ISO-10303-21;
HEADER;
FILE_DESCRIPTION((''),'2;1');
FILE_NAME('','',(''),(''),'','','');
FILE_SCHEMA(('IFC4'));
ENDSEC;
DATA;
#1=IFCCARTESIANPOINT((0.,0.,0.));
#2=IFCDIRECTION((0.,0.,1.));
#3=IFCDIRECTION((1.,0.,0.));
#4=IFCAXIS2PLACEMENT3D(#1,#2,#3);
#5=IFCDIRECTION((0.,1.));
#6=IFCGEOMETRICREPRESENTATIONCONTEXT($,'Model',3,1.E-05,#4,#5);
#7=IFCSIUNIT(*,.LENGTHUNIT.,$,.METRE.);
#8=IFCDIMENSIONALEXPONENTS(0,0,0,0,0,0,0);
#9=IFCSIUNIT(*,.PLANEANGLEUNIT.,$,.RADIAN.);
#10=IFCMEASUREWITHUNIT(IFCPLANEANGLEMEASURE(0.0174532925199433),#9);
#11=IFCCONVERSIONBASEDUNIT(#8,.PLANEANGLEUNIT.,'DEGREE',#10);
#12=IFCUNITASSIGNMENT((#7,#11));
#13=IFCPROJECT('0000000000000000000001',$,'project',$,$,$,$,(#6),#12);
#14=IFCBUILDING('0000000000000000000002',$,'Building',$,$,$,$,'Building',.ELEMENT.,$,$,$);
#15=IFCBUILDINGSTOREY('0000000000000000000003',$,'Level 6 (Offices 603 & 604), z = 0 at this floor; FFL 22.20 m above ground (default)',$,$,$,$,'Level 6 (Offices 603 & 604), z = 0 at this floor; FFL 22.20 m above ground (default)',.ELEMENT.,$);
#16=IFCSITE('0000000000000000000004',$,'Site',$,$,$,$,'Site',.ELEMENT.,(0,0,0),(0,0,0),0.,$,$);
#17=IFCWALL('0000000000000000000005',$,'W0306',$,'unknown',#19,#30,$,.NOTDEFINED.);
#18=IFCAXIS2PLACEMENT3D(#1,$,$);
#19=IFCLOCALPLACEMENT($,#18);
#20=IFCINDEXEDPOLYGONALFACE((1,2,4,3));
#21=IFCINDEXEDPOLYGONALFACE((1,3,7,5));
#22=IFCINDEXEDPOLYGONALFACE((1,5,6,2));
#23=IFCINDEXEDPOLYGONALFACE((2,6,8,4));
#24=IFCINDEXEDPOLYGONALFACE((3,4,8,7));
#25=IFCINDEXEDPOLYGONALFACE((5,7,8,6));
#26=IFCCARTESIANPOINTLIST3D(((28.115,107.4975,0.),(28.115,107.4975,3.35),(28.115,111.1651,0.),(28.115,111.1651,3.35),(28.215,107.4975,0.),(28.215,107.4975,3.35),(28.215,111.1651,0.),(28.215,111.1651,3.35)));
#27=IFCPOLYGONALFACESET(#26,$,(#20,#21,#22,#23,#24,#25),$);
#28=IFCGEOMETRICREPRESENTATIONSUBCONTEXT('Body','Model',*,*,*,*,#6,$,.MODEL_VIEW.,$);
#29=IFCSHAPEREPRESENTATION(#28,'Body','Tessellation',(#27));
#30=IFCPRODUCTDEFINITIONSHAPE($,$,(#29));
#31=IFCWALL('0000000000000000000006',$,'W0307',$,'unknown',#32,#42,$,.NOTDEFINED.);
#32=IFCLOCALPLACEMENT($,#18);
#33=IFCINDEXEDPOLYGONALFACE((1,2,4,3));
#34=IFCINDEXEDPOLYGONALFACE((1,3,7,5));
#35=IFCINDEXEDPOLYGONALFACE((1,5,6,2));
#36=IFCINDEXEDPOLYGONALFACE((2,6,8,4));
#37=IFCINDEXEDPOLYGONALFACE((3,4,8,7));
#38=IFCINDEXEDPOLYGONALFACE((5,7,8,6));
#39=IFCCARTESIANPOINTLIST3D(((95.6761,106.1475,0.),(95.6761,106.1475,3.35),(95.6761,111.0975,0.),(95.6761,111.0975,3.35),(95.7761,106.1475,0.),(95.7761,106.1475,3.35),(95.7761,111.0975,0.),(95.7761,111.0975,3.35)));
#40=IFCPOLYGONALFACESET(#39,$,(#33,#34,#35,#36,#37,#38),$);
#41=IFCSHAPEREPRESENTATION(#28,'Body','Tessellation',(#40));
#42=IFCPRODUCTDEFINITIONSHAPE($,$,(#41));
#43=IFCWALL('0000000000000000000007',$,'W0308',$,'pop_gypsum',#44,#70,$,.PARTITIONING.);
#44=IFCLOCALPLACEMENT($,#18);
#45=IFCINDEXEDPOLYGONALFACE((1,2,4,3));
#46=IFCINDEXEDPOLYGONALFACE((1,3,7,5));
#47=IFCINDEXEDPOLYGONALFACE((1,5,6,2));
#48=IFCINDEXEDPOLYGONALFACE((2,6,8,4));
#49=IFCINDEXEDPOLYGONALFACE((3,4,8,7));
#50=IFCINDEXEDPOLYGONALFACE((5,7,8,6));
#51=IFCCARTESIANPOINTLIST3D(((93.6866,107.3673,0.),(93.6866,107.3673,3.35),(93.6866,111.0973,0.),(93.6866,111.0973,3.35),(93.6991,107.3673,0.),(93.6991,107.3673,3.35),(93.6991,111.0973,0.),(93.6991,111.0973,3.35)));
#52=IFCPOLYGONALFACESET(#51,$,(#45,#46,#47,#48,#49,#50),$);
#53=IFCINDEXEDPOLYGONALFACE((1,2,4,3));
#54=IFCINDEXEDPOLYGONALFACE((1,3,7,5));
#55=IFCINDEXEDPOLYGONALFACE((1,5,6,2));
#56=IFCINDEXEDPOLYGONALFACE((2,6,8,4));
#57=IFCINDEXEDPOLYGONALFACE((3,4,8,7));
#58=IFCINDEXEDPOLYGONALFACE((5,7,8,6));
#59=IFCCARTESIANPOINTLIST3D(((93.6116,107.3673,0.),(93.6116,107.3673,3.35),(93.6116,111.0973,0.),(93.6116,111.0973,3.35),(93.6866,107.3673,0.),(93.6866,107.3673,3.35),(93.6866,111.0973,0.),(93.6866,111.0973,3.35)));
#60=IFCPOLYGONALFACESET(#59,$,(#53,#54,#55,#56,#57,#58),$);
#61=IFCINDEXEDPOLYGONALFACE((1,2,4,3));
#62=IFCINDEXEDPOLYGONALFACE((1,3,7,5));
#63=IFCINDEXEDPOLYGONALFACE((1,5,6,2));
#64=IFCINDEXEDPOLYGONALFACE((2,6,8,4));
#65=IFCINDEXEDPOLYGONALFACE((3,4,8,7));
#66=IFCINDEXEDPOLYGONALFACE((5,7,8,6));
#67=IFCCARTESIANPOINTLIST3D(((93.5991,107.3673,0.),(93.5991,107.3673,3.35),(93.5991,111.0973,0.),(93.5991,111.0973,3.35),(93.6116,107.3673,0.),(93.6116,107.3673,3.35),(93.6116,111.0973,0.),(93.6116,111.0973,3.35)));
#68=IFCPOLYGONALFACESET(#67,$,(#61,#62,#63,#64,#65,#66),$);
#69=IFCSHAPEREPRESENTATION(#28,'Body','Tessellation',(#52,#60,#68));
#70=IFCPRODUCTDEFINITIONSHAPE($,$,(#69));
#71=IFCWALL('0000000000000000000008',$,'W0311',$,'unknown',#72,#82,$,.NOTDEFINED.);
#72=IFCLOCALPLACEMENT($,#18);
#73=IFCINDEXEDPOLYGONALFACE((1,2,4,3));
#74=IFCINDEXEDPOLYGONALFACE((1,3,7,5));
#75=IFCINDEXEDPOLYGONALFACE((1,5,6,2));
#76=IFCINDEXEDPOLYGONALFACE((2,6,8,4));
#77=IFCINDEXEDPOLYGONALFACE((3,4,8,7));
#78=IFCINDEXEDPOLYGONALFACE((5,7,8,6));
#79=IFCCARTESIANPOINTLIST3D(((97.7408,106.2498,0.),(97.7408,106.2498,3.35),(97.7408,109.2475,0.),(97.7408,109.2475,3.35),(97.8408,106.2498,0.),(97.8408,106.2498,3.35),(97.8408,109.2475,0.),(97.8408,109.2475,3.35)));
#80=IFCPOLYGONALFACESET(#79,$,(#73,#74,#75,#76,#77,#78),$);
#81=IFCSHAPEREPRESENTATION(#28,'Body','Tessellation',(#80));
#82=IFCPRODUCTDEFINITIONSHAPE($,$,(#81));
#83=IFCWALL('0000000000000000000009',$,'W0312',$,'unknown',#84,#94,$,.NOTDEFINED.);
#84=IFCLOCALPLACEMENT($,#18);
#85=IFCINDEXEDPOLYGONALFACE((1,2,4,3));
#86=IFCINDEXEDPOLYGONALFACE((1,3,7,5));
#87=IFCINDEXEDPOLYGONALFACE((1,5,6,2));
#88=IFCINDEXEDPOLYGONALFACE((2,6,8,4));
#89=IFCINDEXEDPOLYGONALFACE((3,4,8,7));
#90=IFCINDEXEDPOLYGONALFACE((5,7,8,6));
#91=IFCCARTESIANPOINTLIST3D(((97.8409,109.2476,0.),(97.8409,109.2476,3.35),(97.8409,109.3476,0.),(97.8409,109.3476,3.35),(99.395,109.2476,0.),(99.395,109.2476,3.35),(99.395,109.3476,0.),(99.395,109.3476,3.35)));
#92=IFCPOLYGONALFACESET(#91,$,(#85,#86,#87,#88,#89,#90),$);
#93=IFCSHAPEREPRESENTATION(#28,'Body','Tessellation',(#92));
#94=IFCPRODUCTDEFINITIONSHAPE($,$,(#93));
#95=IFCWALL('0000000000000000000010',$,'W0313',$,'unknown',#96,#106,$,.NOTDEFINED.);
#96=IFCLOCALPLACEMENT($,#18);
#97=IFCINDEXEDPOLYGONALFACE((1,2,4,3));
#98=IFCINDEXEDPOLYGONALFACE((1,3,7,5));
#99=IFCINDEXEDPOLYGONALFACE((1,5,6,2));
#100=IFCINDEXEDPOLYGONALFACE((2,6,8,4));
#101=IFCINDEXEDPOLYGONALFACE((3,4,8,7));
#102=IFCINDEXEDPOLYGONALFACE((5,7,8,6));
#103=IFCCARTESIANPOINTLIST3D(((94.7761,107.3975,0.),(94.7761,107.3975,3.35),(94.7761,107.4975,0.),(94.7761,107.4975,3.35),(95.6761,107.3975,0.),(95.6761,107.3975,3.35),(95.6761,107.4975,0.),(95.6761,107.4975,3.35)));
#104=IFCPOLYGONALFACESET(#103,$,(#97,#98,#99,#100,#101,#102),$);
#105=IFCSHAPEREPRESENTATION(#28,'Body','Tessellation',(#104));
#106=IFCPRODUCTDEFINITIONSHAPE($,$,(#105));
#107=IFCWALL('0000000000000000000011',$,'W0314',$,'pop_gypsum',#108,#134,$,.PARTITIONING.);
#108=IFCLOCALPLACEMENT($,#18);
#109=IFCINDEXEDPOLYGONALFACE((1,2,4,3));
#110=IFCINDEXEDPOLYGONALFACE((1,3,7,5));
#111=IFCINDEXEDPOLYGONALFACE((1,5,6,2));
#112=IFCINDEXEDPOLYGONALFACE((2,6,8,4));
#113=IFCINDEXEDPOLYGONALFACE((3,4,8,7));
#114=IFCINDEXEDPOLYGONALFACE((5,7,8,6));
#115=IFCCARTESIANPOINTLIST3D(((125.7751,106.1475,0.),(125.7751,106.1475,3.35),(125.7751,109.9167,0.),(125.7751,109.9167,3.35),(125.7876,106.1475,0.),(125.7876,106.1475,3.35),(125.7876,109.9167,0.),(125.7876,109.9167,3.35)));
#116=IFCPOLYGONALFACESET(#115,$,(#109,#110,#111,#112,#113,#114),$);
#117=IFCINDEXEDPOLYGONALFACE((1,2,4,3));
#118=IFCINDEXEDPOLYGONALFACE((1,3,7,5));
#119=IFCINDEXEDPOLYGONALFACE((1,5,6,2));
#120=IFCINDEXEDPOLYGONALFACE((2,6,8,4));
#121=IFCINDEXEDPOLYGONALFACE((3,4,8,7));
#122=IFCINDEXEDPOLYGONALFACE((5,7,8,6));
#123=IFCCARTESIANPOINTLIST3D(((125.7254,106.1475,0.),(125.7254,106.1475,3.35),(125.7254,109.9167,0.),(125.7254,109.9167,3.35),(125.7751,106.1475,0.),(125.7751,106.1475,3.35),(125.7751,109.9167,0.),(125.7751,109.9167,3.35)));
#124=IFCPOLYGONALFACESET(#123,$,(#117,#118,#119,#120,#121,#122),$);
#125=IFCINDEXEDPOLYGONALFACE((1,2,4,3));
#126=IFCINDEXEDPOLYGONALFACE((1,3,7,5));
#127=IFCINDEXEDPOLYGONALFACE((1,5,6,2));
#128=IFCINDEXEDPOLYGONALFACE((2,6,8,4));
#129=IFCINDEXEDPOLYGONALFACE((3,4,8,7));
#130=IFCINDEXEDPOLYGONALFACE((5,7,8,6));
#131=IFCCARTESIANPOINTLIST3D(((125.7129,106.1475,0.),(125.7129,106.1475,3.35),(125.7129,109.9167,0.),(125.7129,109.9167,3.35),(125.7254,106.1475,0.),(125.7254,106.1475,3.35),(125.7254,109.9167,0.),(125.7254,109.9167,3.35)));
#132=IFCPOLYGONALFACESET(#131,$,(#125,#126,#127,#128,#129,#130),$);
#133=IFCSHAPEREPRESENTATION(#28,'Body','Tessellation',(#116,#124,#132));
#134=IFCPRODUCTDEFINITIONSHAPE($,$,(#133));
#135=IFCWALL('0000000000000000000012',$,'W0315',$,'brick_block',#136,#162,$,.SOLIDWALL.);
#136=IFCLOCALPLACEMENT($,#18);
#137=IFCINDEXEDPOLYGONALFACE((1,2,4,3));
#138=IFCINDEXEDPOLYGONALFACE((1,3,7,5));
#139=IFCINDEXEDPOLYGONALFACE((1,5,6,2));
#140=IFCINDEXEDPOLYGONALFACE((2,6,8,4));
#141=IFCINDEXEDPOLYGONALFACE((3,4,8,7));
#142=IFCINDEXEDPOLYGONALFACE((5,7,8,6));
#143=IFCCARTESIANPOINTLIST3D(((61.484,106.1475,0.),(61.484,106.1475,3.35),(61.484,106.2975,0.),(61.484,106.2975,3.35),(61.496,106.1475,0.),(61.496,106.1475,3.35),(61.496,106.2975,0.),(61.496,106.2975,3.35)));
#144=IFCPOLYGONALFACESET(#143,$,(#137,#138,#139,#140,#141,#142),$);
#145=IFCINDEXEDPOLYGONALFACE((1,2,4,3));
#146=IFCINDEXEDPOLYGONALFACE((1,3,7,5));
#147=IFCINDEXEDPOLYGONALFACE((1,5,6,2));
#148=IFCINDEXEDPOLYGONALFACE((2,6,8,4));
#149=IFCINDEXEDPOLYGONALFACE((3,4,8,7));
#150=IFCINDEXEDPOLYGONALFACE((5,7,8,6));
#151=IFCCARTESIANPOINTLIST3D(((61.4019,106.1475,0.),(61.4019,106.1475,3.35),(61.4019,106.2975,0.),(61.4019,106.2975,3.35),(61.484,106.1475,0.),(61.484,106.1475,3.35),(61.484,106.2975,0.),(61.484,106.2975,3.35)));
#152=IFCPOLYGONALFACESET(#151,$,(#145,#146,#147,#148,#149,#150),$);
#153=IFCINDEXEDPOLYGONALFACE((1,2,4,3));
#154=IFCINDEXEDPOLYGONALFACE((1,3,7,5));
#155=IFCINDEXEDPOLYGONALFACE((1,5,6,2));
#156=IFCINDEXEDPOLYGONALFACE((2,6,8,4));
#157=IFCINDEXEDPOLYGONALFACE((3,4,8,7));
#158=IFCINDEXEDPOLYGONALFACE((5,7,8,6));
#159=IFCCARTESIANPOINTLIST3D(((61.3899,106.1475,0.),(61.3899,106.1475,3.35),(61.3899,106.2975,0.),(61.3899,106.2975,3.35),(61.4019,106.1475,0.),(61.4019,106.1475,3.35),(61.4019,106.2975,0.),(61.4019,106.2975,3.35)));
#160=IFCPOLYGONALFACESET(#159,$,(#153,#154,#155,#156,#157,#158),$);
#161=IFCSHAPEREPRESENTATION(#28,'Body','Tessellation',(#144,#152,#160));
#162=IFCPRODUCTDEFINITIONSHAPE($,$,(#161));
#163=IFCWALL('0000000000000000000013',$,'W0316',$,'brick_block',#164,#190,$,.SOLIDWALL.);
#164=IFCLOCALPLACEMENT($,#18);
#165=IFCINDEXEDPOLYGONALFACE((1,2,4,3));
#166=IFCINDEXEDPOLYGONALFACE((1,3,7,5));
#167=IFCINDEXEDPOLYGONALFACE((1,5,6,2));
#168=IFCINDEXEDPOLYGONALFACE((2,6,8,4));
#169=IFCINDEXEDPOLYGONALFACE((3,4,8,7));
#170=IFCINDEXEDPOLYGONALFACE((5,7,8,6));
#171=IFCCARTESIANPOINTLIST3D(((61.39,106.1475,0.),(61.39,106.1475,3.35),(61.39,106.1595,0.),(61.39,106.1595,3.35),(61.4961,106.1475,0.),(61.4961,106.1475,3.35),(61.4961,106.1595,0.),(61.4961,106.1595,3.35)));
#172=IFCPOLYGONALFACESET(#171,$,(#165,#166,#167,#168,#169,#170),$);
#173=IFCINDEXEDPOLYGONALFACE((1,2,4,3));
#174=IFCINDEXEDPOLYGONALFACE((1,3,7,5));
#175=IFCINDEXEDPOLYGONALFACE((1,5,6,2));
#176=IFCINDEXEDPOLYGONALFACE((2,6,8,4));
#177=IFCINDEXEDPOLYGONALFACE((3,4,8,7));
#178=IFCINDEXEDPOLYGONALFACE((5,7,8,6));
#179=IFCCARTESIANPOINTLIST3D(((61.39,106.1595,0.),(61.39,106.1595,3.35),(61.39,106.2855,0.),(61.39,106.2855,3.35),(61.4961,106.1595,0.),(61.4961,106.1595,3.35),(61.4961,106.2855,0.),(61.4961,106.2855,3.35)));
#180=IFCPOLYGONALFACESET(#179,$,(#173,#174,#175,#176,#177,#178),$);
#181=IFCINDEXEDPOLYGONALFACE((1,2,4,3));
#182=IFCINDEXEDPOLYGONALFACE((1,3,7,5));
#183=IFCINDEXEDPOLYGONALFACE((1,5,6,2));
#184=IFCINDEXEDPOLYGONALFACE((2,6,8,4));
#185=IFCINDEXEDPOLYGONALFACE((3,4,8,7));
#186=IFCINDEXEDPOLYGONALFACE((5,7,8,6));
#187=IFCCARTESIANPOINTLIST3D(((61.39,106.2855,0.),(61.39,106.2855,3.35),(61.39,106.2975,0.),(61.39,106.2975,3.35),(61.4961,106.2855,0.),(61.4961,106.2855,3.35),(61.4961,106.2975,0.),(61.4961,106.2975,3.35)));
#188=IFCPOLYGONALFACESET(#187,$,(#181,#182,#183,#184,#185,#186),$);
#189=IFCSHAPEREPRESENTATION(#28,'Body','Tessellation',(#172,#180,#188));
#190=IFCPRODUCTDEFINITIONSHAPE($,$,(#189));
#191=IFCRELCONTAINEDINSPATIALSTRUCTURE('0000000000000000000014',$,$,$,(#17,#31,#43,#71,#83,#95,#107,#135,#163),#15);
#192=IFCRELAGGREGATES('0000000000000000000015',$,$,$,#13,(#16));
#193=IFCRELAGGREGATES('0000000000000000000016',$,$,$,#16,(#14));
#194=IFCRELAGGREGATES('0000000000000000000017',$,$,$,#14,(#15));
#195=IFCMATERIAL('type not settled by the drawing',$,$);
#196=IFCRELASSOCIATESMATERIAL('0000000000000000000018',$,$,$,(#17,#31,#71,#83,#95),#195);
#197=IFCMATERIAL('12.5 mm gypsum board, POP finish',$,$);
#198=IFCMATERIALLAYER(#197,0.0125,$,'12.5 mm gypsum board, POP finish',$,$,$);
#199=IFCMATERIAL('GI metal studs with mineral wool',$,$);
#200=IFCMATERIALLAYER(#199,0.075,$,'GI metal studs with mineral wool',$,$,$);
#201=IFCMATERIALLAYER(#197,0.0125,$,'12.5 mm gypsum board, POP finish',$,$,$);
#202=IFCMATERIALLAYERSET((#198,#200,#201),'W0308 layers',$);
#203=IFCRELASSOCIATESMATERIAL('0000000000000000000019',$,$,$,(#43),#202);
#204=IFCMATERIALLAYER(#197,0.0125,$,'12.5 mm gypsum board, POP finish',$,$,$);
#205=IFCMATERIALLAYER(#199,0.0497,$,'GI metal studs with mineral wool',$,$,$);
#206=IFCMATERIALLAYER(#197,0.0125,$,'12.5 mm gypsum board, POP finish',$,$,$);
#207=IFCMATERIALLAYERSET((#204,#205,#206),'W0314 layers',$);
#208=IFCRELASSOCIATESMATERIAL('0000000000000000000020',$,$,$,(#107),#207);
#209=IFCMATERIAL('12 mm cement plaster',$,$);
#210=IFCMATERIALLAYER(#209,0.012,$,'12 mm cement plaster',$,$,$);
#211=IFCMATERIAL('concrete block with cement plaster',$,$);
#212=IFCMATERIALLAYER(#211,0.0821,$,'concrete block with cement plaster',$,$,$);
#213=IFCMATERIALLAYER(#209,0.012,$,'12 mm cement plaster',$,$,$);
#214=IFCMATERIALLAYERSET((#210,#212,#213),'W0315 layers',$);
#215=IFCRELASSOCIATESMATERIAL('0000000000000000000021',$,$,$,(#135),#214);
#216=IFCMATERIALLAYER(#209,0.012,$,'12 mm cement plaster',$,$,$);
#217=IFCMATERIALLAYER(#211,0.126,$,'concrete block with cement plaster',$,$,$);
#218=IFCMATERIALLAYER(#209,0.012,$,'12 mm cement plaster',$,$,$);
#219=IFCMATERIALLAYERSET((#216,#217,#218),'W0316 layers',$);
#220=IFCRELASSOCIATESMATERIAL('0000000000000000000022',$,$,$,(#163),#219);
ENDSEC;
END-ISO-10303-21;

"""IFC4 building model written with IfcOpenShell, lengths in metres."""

from ifc_helpers import new_model, entity, si_unit, converted_unit, direction, frame, frame_2d, origin_with_axes, origin_2d_with_axis, place, context, subcontext, project, spatial, rectangle, extrude, material, layer, layer_set, layer_usage, element, save


model = new_model("IFC4")

# Units and contexts
model_context = context("Model", 3, precision=1e-05, world=origin_with_axes(), true_north=direction((0.0, 1.0)))
body_context = subcontext(model_context, "Body", "Model", "MODEL_VIEW")
ifc_project = project(units=[si_unit("LENGTHUNIT", "METRE"), converted_unit("PLANEANGLEUNIT", "DEGREE", entity("IfcPlaneAngleMeasure", 0.0174532925199433), si_unit("PLANEANGLEUNIT", "RADIAN"), dimensions=[0, 0, 0, 0, 0, 0, 0])], contexts=[model_context])

# Site, building, storey
site = spatial("IfcSite", under=ifc_project, Name="Site", LongName="Site", CompositionType="ELEMENT", RefLatitude=(0, 0, 0), RefLongitude=(0, 0, 0), RefElevation=0.0)
building = spatial("IfcBuilding", under=site, Name="Building", LongName="Building", CompositionType="ELEMENT")
storey = spatial("IfcBuildingStorey", under=building, Name="Level 6 (Offices 603 & 604), z = 0 at this floor; FFL 22.20 m above ground (default)", LongName="Level 6 (Offices 603 & 604), z = 0 at this floor; FFL 22.20 m above ground (default)", CompositionType="ELEMENT")

# Walls
ifc_material_1 = material(Name="type not settled by the drawing")
placement = place(None, origin_with_axes())
element("IfcWall", 1, at=placement, inside=storey, material=ifc_material_1, Name="W0306", ObjectType="unknown", PredefinedType="NOTDEFINED", context=body_context, shape_type="SweptSolid", body=[
    extrude(rectangle(XDim=3.6676, YDim=0.1, at=frame_2d((0.0, 0.0), x_axis=(0.0, 1.0))), frame((28.165, 109.3313, 0.0), z_axis=(0.0, 0.0, 1.0), x_axis=(1.0, 0.0, 0.0)), (0.0, 0.0, 1.0), 3.35),
])
element("IfcWall", 2, at=placement, inside=storey, material=ifc_material_1, Name="W0307", ObjectType="unknown", PredefinedType="NOTDEFINED", context=body_context, shape_type="SweptSolid", body=[
    extrude(rectangle(XDim=4.95, YDim=0.1, at=frame_2d((0.0, 0.0), x_axis=(0.0, 1.0))), frame((95.7261, 108.6225, 0.0), z_axis=(0.0, 0.0, 1.0), x_axis=(1.0, 0.0, 0.0)), (0.0, 0.0, 1.0), 3.35),
])
ifc_material_2 = material(Name="12.5 mm gypsum board, POP finish")
ifc_layer_1 = layer(ifc_material_2, 0.0125, Name="12.5 mm gypsum board, POP finish")
ifc_material_3 = material(Name="GI metal studs with mineral wool")
ifc_layer_2 = layer(ifc_material_3, 0.075, Name="GI metal studs with mineral wool")
ifc_layer_3 = layer(ifc_material_2, 0.0125, Name="12.5 mm gypsum board, POP finish")
ifc_layer_set_1 = layer_set([ifc_layer_1, ifc_layer_2, ifc_layer_3], Name="W0308 layers")
ifc_layer_usage_1 = layer_usage(ifc_layer_set_1, "AXIS2", "POSITIVE", -0.05)
element("IfcWall", 3, at=placement, inside=storey, material=ifc_layer_usage_1, Name="W0308", ObjectType="pop_gypsum", PredefinedType="PARTITIONING", context=body_context, shape_type="SweptSolid", body=[
    extrude(rectangle(XDim=3.73, YDim=0.0125, at=frame_2d((0.0, 0.0), x_axis=(0.0, 1.0))), frame((93.6929, 109.2323, 0.0), z_axis=(0.0, 0.0, 1.0), x_axis=(1.0, 0.0, 0.0)), (0.0, 0.0, 1.0), 3.35),
    extrude(rectangle(XDim=3.73, YDim=0.075, at=frame_2d((-0.0437, 0.0), x_axis=(0.0, 1.0))), frame((93.6929, 109.2323, 0.0), z_axis=(0.0, 0.0, 1.0), x_axis=(1.0, 0.0, 0.0)), (0.0, 0.0, 1.0), 3.35),
    extrude(rectangle(XDim=3.73, YDim=0.0125, at=frame_2d((-0.0875, 0.0), x_axis=(0.0, 1.0))), frame((93.6929, 109.2323, 0.0), z_axis=(0.0, 0.0, 1.0), x_axis=(1.0, 0.0, 0.0)), (0.0, 0.0, 1.0), 3.35),
])
element("IfcWall", 4, at=placement, inside=storey, material=ifc_material_1, Name="W0311", ObjectType="unknown", PredefinedType="NOTDEFINED", context=body_context, shape_type="SweptSolid", body=[
    extrude(rectangle(XDim=2.9977, YDim=0.1001, at=frame_2d((0.0, 0.0), x_axis=(0.0, 1.0))), frame((97.7908, 107.7486, 0.0), z_axis=(0.0, 0.0, 1.0), x_axis=(1.0, 0.0, 0.0)), (0.0, 0.0, 1.0), 3.35),
])
element("IfcWall", 5, at=placement, inside=storey, material=ifc_material_1, Name="W0312", ObjectType="unknown", PredefinedType="NOTDEFINED", context=body_context, shape_type="SweptSolid", body=[
    extrude(rectangle(XDim=1.5541, YDim=0.1001, at=origin_2d_with_axis()), frame((98.6179, 109.2976, 0.0), z_axis=(0.0, 0.0, 1.0), x_axis=(1.0, 0.0, 0.0)), (0.0, 0.0, 1.0), 3.35),
])
element("IfcWall", 6, at=placement, inside=storey, material=ifc_material_1, Name="W0313", ObjectType="unknown", PredefinedType="NOTDEFINED", context=body_context, shape_type="SweptSolid", body=[
    extrude(rectangle(XDim=0.9, YDim=0.1, at=frame_2d((0.0, 0.0), x_axis=(1.0, 0.0))), frame((95.2261, 107.4475, 0.0), z_axis=(0.0, 0.0, 1.0), x_axis=(1.0, 0.0, 0.0)), (0.0, 0.0, 1.0), 3.35),
])
ifc_layer_4 = layer(ifc_material_2, 0.0125, Name="12.5 mm gypsum board, POP finish")
ifc_layer_5 = layer(ifc_material_3, 0.0497, Name="GI metal studs with mineral wool")
ifc_layer_6 = layer(ifc_material_2, 0.0125, Name="12.5 mm gypsum board, POP finish")
ifc_layer_set_2 = layer_set([ifc_layer_4, ifc_layer_5, ifc_layer_6], Name="W0314 layers")
ifc_layer_usage_2 = layer_usage(ifc_layer_set_2, "AXIS2", "POSITIVE", -0.0374)
element("IfcWall", 7, at=placement, inside=storey, material=ifc_layer_usage_2, Name="W0314", ObjectType="pop_gypsum", PredefinedType="PARTITIONING", context=body_context, shape_type="SweptSolid", body=[
    extrude(rectangle(XDim=3.7692, YDim=0.0125, at=frame_2d((0.0, 0.0), x_axis=(0.0, 1.0))), frame((125.7814, 108.0321, 0.0), z_axis=(0.0, 0.0, 1.0), x_axis=(1.0, 0.0, 0.0)), (0.0, 0.0, 1.0), 3.35),
    extrude(rectangle(XDim=3.7692, YDim=0.0497, at=frame_2d((-0.0311, 0.0), x_axis=(0.0, 1.0))), frame((125.7814, 108.0321, 0.0), z_axis=(0.0, 0.0, 1.0), x_axis=(1.0, 0.0, 0.0)), (0.0, 0.0, 1.0), 3.35),
    extrude(rectangle(XDim=3.7692, YDim=0.0125, at=frame_2d((-0.0622, 0.0), x_axis=(0.0, 1.0))), frame((125.7814, 108.0321, 0.0), z_axis=(0.0, 0.0, 1.0), x_axis=(1.0, 0.0, 0.0)), (0.0, 0.0, 1.0), 3.35),
])
ifc_material_4 = material(Name="12 mm cement plaster")
ifc_layer_7 = layer(ifc_material_4, 0.012, Name="12 mm cement plaster")
ifc_material_5 = material(Name="concrete block with cement plaster")
ifc_layer_8 = layer(ifc_material_5, 0.0821, Name="concrete block with cement plaster")
ifc_layer_9 = layer(ifc_material_4, 0.012, Name="12 mm cement plaster")
ifc_layer_set_3 = layer_set([ifc_layer_7, ifc_layer_8, ifc_layer_9], Name="W0315 layers")
ifc_layer_usage_3 = layer_usage(ifc_layer_set_3, "AXIS2", "POSITIVE", -0.053)
element("IfcWall", 8, at=placement, inside=storey, material=ifc_layer_usage_3, Name="W0315", ObjectType="brick_block", PredefinedType="SOLIDWALL", context=body_context, shape_type="SweptSolid", body=[
    extrude(rectangle(XDim=0.15, YDim=0.012, at=frame_2d((0.0, 0.0), x_axis=(0.0, 1.0))), frame((61.49, 106.2225, 0.0), z_axis=(0.0, 0.0, 1.0), x_axis=(1.0, 0.0, 0.0)), (0.0, 0.0, 1.0), 3.35),
    extrude(rectangle(XDim=0.15, YDim=0.0821, at=frame_2d((-0.0471, 0.0), x_axis=(0.0, 1.0))), frame((61.49, 106.2225, 0.0), z_axis=(0.0, 0.0, 1.0), x_axis=(1.0, 0.0, 0.0)), (0.0, 0.0, 1.0), 3.35),
    extrude(rectangle(XDim=0.15, YDim=0.012, at=frame_2d((-0.0941, 0.0), x_axis=(0.0, 1.0))), frame((61.49, 106.2225, 0.0), z_axis=(0.0, 0.0, 1.0), x_axis=(1.0, 0.0, 0.0)), (0.0, 0.0, 1.0), 3.35),
])
ifc_layer_10 = layer(ifc_material_4, 0.012, Name="12 mm cement plaster")
ifc_layer_11 = layer(ifc_material_5, 0.126, Name="concrete block with cement plaster")
ifc_layer_12 = layer(ifc_material_4, 0.012, Name="12 mm cement plaster")
ifc_layer_set_4 = layer_set([ifc_layer_10, ifc_layer_11, ifc_layer_12], Name="W0316 layers")
ifc_layer_usage_4 = layer_usage(ifc_layer_set_4, "AXIS2", "POSITIVE", -0.075)
element("IfcWall", 9, at=placement, inside=storey, material=ifc_layer_usage_4, Name="W0316", ObjectType="brick_block", PredefinedType="SOLIDWALL", context=body_context, shape_type="SweptSolid", body=[
    extrude(rectangle(XDim=0.1061, YDim=0.012, at=frame_2d((0.0, 0.0), x_axis=(1.0, 0.0))), frame((61.443, 106.1535, 0.0), z_axis=(0.0, 0.0, 1.0), x_axis=(1.0, 0.0, 0.0)), (0.0, 0.0, 1.0), 3.35),
    extrude(rectangle(XDim=0.1061, YDim=0.126, at=frame_2d((0.0, 0.069), x_axis=(1.0, 0.0))), frame((61.443, 106.1535, 0.0), z_axis=(0.0, 0.0, 1.0), x_axis=(1.0, 0.0, 0.0)), (0.0, 0.0, 1.0), 3.35),
    extrude(rectangle(XDim=0.1061, YDim=0.012, at=frame_2d((0.0, 0.138), x_axis=(1.0, 0.0))), frame((61.443, 106.1535, 0.0), z_axis=(0.0, 0.0, 1.0), x_axis=(1.0, 0.0, 0.0)), (0.0, 0.0, 1.0), 3.35),
])

save(model, "model.ifc")
